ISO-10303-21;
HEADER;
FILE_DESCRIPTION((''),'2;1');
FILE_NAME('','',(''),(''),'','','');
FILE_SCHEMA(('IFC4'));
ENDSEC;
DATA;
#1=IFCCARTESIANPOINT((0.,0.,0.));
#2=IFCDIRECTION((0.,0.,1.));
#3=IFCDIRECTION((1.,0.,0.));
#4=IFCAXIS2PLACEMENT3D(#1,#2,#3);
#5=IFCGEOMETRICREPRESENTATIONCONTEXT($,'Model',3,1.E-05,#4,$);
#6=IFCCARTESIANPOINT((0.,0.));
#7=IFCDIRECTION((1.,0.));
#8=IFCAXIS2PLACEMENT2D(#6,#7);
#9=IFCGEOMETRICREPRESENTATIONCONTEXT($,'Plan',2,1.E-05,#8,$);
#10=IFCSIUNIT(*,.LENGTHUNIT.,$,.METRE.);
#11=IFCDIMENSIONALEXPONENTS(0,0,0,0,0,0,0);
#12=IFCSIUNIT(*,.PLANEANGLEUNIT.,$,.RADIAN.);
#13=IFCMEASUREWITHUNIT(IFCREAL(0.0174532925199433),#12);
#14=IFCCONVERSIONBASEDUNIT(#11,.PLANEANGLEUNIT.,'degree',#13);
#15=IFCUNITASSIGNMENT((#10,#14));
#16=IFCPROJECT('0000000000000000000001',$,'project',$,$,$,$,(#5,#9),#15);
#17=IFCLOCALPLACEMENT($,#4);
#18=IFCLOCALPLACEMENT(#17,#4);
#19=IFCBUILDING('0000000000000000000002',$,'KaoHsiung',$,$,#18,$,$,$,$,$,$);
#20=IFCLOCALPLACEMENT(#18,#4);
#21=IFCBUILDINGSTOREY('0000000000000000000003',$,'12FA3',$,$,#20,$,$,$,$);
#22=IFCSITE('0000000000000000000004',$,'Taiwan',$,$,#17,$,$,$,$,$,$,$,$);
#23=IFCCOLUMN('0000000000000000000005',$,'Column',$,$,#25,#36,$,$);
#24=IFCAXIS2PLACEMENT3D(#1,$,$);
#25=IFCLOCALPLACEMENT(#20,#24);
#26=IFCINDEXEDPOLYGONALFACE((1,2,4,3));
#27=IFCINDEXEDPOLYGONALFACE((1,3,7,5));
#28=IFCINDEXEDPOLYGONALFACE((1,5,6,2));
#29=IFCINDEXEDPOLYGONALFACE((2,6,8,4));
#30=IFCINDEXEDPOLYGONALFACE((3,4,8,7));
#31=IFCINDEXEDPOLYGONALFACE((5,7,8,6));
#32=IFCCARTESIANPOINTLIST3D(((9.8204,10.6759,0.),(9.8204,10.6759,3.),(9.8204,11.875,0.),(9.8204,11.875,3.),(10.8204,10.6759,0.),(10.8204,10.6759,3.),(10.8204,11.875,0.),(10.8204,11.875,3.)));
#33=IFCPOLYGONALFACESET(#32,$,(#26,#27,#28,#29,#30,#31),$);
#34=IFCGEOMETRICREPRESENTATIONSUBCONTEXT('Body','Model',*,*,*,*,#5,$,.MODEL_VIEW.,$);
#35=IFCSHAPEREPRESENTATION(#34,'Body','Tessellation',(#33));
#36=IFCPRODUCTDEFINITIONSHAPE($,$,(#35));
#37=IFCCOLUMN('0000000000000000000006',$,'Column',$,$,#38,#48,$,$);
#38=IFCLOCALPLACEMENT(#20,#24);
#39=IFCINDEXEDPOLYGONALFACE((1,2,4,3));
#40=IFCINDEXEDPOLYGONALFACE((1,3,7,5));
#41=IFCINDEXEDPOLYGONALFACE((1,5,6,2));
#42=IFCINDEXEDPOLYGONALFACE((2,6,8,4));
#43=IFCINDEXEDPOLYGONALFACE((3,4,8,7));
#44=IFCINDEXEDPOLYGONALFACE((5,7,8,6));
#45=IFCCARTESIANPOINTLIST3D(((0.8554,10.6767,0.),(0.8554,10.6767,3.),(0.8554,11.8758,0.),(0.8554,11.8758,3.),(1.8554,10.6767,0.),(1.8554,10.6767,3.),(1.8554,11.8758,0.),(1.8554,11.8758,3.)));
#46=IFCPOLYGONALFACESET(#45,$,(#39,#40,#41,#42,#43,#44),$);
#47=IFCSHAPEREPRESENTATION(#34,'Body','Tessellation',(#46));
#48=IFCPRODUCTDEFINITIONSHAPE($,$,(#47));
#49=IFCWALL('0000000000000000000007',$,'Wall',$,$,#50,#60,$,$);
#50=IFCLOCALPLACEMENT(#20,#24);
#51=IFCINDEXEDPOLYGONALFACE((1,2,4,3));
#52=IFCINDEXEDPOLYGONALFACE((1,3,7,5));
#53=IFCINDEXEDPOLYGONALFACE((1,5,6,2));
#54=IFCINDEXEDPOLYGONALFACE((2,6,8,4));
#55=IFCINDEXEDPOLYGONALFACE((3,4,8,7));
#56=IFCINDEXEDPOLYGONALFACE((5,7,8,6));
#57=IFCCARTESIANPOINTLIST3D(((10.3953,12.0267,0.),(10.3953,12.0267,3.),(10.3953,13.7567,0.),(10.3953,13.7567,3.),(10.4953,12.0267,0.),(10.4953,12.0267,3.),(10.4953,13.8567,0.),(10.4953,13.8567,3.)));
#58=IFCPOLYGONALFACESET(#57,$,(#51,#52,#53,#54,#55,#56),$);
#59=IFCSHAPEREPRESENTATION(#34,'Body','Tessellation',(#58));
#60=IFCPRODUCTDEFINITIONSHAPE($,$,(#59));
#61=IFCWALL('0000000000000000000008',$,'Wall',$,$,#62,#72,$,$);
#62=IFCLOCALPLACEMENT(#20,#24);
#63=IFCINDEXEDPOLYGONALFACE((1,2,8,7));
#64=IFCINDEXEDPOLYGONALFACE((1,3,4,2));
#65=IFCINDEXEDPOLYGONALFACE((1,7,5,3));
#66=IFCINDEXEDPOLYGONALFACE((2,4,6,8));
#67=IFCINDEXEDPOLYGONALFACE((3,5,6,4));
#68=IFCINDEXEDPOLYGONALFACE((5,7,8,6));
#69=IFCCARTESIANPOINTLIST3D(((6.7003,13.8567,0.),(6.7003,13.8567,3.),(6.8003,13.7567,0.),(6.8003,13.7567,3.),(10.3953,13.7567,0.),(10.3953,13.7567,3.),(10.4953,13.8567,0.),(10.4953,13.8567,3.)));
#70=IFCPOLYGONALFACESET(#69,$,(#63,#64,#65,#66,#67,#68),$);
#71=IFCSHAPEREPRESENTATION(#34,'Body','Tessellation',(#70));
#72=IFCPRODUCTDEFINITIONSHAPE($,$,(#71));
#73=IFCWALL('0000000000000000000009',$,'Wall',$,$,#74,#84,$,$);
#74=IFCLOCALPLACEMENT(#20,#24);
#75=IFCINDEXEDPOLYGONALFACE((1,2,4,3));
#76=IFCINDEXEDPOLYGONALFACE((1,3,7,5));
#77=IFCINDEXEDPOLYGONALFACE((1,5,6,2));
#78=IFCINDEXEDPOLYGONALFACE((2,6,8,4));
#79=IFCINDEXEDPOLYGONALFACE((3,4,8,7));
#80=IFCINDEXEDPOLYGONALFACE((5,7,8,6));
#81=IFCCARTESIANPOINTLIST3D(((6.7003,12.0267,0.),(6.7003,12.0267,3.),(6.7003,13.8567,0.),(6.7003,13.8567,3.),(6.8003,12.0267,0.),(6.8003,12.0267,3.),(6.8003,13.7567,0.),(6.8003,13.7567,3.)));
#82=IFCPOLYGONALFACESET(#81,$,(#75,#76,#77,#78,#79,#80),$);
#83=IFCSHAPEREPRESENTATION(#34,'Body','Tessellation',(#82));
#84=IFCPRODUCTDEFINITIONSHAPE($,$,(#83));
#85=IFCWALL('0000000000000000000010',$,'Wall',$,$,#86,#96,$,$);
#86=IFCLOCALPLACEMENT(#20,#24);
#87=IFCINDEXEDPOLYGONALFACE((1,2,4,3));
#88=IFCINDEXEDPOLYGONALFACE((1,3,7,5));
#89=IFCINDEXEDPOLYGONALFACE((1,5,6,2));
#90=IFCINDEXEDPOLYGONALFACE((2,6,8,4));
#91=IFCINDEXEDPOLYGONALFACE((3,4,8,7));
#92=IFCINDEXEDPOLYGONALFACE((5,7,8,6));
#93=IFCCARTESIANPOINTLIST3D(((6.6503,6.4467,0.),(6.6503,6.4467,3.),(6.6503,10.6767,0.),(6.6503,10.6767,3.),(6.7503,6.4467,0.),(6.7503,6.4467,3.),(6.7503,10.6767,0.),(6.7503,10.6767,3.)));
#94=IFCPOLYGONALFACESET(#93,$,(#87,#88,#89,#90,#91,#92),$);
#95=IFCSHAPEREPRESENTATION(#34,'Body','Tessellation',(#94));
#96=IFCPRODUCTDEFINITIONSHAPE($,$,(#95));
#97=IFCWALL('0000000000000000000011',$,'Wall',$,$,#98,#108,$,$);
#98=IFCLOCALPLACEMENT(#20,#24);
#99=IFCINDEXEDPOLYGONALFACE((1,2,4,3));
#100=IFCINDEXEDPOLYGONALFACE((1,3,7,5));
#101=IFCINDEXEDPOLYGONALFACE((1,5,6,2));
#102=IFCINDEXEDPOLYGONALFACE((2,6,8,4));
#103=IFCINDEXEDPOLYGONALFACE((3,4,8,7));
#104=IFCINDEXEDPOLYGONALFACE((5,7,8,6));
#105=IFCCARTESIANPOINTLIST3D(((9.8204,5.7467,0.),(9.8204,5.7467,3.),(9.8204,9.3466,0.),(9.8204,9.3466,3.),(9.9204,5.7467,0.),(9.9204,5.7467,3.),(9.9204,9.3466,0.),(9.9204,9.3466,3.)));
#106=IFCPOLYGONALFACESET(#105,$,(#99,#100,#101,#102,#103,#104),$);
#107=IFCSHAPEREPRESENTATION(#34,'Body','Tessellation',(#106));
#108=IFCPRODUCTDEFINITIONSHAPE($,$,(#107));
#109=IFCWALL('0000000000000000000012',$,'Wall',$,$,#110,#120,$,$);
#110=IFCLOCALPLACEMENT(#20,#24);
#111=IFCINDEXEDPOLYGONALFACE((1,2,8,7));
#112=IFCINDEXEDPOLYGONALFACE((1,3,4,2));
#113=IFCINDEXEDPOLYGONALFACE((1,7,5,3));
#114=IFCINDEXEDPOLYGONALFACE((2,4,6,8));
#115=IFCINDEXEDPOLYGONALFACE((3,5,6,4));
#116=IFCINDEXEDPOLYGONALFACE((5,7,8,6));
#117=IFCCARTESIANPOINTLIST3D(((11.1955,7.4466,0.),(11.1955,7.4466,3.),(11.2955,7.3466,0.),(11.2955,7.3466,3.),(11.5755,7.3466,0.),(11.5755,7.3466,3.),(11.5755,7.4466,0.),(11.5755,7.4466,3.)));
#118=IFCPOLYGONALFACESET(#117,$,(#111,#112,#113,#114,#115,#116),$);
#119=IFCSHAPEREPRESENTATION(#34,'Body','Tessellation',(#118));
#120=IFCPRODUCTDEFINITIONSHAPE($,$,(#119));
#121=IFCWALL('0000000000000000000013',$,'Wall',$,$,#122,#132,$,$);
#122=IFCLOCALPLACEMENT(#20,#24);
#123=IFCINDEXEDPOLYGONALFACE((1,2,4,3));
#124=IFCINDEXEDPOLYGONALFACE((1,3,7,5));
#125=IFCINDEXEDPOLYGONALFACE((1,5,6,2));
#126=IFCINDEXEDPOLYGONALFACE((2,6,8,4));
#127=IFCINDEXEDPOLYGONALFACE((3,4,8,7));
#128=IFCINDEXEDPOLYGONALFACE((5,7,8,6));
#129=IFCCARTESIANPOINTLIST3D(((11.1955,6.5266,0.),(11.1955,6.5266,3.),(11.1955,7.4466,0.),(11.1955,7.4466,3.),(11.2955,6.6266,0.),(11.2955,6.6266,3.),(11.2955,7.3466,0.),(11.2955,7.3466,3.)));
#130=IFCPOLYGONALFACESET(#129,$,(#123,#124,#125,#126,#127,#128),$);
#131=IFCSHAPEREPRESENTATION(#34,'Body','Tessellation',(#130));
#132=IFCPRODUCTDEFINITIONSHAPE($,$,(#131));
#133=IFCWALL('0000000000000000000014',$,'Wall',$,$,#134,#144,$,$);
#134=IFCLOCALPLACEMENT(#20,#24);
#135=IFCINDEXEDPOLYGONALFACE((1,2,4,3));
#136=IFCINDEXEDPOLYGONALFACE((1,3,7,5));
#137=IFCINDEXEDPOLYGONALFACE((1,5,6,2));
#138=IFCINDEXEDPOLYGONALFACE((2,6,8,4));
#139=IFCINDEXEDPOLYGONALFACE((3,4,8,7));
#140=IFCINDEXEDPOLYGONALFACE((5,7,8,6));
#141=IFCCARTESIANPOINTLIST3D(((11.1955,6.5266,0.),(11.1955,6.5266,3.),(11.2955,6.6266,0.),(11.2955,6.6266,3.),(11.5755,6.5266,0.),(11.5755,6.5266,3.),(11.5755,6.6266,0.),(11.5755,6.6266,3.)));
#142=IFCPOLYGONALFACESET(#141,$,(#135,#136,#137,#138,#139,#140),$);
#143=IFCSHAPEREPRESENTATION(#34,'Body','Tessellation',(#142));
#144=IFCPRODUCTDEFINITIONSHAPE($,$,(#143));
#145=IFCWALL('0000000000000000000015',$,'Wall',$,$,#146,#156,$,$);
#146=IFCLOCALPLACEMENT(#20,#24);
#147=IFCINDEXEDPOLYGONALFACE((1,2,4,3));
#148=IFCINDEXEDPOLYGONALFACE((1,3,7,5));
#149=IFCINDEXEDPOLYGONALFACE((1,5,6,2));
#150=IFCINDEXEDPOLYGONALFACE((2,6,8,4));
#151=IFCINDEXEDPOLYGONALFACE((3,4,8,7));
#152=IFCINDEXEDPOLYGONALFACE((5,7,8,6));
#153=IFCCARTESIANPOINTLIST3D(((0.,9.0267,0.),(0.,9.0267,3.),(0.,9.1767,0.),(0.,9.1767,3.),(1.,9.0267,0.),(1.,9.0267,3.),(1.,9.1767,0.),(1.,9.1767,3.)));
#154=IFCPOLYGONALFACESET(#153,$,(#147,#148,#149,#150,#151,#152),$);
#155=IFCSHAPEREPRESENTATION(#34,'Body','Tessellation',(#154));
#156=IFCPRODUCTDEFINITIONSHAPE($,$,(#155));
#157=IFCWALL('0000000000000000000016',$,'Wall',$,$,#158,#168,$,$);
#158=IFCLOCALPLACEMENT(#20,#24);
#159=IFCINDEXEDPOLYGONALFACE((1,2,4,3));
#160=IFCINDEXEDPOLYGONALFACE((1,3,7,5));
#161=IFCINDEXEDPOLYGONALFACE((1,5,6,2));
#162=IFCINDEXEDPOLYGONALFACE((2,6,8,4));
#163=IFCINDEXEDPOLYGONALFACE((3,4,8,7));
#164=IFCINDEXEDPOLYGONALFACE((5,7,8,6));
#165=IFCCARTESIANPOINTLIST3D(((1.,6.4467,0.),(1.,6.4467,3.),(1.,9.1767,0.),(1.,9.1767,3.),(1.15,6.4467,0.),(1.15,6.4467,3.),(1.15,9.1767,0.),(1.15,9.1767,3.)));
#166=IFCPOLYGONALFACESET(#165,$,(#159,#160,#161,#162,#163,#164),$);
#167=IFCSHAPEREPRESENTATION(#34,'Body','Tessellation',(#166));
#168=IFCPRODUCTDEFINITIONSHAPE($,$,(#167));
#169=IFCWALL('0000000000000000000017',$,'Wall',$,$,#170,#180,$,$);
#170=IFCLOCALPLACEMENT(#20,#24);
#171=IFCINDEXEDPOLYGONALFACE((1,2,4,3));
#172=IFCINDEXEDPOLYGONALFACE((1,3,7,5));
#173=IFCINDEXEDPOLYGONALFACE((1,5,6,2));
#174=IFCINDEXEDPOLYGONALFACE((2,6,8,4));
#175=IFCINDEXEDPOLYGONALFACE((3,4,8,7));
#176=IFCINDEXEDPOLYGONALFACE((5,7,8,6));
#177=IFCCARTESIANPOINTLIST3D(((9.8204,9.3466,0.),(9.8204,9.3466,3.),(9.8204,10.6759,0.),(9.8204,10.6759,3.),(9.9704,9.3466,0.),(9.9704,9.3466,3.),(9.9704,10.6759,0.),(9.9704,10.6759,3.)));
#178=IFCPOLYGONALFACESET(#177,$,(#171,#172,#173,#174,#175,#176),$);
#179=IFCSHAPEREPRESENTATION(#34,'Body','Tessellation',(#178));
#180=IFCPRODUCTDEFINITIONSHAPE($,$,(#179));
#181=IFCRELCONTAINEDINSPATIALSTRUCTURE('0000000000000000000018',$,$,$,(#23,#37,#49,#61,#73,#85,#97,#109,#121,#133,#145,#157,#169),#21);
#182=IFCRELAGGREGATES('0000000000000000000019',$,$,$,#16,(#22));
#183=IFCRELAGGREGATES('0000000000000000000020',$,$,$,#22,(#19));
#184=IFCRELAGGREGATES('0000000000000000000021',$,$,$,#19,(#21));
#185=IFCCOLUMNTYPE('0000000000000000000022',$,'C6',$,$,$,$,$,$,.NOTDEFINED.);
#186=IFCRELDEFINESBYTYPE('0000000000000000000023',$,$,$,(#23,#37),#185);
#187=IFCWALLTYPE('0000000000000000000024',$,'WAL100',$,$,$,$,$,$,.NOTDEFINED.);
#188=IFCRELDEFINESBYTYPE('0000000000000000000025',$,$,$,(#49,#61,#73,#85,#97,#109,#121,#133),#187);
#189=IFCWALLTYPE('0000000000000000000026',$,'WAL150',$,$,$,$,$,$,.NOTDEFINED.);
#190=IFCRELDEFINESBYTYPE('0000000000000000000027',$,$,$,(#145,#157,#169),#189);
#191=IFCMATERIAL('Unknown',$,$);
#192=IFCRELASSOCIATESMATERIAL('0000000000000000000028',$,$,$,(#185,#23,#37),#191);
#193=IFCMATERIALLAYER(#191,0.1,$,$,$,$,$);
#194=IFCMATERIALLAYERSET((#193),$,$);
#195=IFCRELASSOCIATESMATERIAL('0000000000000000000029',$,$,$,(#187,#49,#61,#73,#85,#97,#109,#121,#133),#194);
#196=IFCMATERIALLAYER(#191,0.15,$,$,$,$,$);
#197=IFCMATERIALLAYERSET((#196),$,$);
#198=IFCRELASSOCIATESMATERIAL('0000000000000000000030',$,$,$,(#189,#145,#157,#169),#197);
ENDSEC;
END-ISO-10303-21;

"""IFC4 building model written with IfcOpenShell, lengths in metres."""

from ifc_helpers import new_model, entity, si_unit, converted_unit, frame, origin_with_axes, origin_2d_with_axis, place, context, subcontext, project, spatial, line, indexed_curve, outline, extrude, material, layer, layer_set, layer_usage, material_profile, profile_set, profile_usage, type_object, element, save


model = new_model("IFC4")

# Units and contexts
model_context = context("Model", 3, precision=1e-05, world=origin_with_axes())
plan_context = context("Plan", 2, precision=1e-05, world=origin_2d_with_axis())
body_context = subcontext(model_context, "Body", "Model", "MODEL_VIEW")
ifc_project = project(units=[si_unit("LENGTHUNIT", "METRE"), converted_unit("PLANEANGLEUNIT", "degree", entity("IfcReal", 0.0174532925199433), si_unit("PLANEANGLEUNIT", "RADIAN"), dimensions=[0, 0, 0, 0, 0, 0, 0])], contexts=[model_context, plan_context])

# Site, building, storey
site_placement = place(None, origin_with_axes())
site = spatial("IfcSite", under=ifc_project, at=site_placement, Name="Taiwan")
building_placement = place(site_placement, origin_with_axes())
building = spatial("IfcBuilding", under=site, at=building_placement, Name="KaoHsiung")
storey_placement = place(building_placement, origin_with_axes())
storey = spatial("IfcBuildingStorey", under=building, at=storey_placement, Name="12FA3")

# Columns
ifc_material = material(Name="Unknown")
ifc_material_profile = material_profile(ifc_material, outline(indexed_curve([(0.0, 1.1992), (1.0, 1.1992), (1.0, 0.0), (0.0, 0.0), (0.0, 1.1992)])))
ifc_profile_set = profile_set([ifc_material_profile])
ifc_profile_usage_1 = profile_usage(ifc_profile_set, cardinal=5)
column_type = type_object("IfcColumnType", Name="C6", PredefinedType="NOTDEFINED", material=ifc_profile_set)
column_1_placement = place(storey_placement, frame((9.8204, 10.6759, 0.0), z_axis=(0.0, 0.0, 1.0), x_axis=(1.0, 0.0, 0.0)))
element("IfcColumn", 1, at=column_1_placement, inside=storey, type_object=column_type, material=ifc_profile_usage_1, Name="Column", context=body_context, shape_type="SweptSolid", body=[
    extrude(outline(indexed_curve([(0.0, 1.1992), (1.0, 1.1992), (1.0, 0.0), (0.0, 0.0), (0.0, 1.1992)])), origin_with_axes(), (0.0, 0.0, 1.0), 3.0),
])
ifc_profile_usage_2 = profile_usage(ifc_profile_set, cardinal=5)
column_2_placement = place(storey_placement, frame((0.8554, 10.6767, 0.0), z_axis=(0.0, 0.0, 1.0), x_axis=(1.0, 0.0, 0.0)))
element("IfcColumn", 2, at=column_2_placement, inside=storey, type_object=column_type, material=ifc_profile_usage_2, Name="Column", context=body_context, shape_type="SweptSolid", body=[
    extrude(outline(indexed_curve([(0.0, 1.1992), (1.0, 1.1992), (1.0, 0.0), (0.0, 0.0), (0.0, 1.1992)])), origin_with_axes(), (0.0, 0.0, 1.0), 3.0),
])

# Walls
ifc_layer_1 = layer(ifc_material, 0.1)
ifc_layer_set_1 = layer_set([ifc_layer_1])
ifc_layer_usage_1 = layer_usage(ifc_layer_set_1, "AXIS2", "POSITIVE", 0.0)
wall_type_1 = type_object("IfcWallType", Name="WAL100", PredefinedType="NOTDEFINED", material=ifc_layer_set_1)
wall_1_placement = place(storey_placement, frame((10.4953, 12.0267, 0.0), z_axis=(0.0, 0.0, 1.0), x_axis=(0.0, 1.0, 0.0)))
element("IfcWall", 3, at=wall_1_placement, inside=storey, type_object=wall_type_1, material=ifc_layer_usage_1, Name="Wall", context=body_context, shape_type="SweptSolid", body=[
    extrude(outline(indexed_curve([(0.0, 0.0), (0.0, 0.1), (1.73, 0.1), (1.83, 0.0)], segments=[line(1, 2, 3, 4, 1)])), origin_with_axes(), (0.0, 0.0, 1.0), 3.0),
])
ifc_layer_usage_2 = layer_usage(ifc_layer_set_1, "AXIS2", "POSITIVE", 0.0)
wall_2_placement = place(storey_placement, frame((10.4953, 13.8567, 0.0), z_axis=(0.0, 0.0, 1.0), x_axis=(-1.0, 0.0, 0.0)))
element("IfcWall", 4, at=wall_2_placement, inside=storey, type_object=wall_type_1, material=ifc_layer_usage_2, Name="Wall", context=body_context, shape_type="SweptSolid", body=[
    extrude(outline(indexed_curve([(0.0, 0.0), (0.1, 0.1), (3.695, 0.1), (3.795, 0.0)], segments=[line(1, 2, 3, 4, 1)])), origin_with_axes(), (0.0, 0.0, 1.0), 3.0),
])
ifc_layer_usage_3 = layer_usage(ifc_layer_set_1, "AXIS2", "POSITIVE", 0.0)
wall_3_placement = place(storey_placement, frame((6.7003, 13.8567, 0.0), z_axis=(0.0, 0.0, 1.0), x_axis=(0.0, -1.0, 0.0)))
element("IfcWall", 5, at=wall_3_placement, inside=storey, type_object=wall_type_1, material=ifc_layer_usage_3, Name="Wall", context=body_context, shape_type="SweptSolid", body=[
    extrude(outline(indexed_curve([(0.0, 0.0), (0.1, 0.1), (1.8299, 0.1), (1.8299, 0.0)], segments=[line(1, 2, 3, 4, 1)])), origin_with_axes(), (0.0, 0.0, 1.0), 3.0),
])
ifc_layer_usage_4 = layer_usage(ifc_layer_set_1, "AXIS2", "POSITIVE", 0.0)
wall_4_placement = place(storey_placement, frame((6.6503, 10.6767, 0.0), z_axis=(0.0, 0.0, 1.0), x_axis=(0.0, -1.0, 0.0)))
element("IfcWall", 6, at=wall_4_placement, inside=storey, type_object=wall_type_1, material=ifc_layer_usage_4, Name="Wall", context=body_context, shape_type="SweptSolid", body=[
    extrude(outline(indexed_curve([(0.0, 0.0), (0.0, 0.1), (4.23, 0.1), (4.23, 0.0)], segments=[line(1, 2, 3, 4, 1)])), origin_with_axes(), (0.0, 0.0, 1.0), 3.0),
])
ifc_layer_usage_5 = layer_usage(ifc_layer_set_1, "AXIS2", "POSITIVE", 0.0)
wall_5_placement = place(storey_placement, frame((9.8204, 9.3466, 0.0), z_axis=(0.0, 0.0, 1.0), x_axis=(0.0, -1.0, 0.0)))
element("IfcWall", 7, at=wall_5_placement, inside=storey, type_object=wall_type_1, material=ifc_layer_usage_5, Name="Wall", context=body_context, shape_type="SweptSolid", body=[
    extrude(outline(indexed_curve([(0.0, 0.0), (0.0, 0.1), (3.5999, 0.1), (3.5999, 0.0)], segments=[line(1, 2, 3, 4, 1)])), origin_with_axes(), (0.0, 0.0, 1.0), 3.0),
])
ifc_layer_usage_6 = layer_usage(ifc_layer_set_1, "AXIS2", "POSITIVE", 0.0)
wall_6_placement = place(storey_placement, frame((11.5755, 7.4466, 0.0), z_axis=(0.0, 0.0, 1.0), x_axis=(-1.0, 0.0, 0.0)))
element("IfcWall", 8, at=wall_6_placement, inside=storey, type_object=wall_type_1, material=ifc_layer_usage_6, Name="Wall", context=body_context, shape_type="SweptSolid", body=[
    extrude(outline(indexed_curve([(0.0, 0.0), (0.0, 0.1), (0.28, 0.1), (0.38, 0.0)], segments=[line(1, 2, 3, 4, 1)])), origin_with_axes(), (0.0, 0.0, 1.0), 3.0),
])
ifc_layer_usage_7 = layer_usage(ifc_layer_set_1, "AXIS2", "POSITIVE", 0.0)
wall_7_placement = place(storey_placement, frame((11.1955, 7.4466, 0.0), z_axis=(0.0, 0.0, 1.0), x_axis=(0.0, -1.0, 0.0)))
element("IfcWall", 9, at=wall_7_placement, inside=storey, type_object=wall_type_1, material=ifc_layer_usage_7, Name="Wall", context=body_context, shape_type="SweptSolid", body=[
    extrude(outline(indexed_curve([(0.0, 0.0), (0.1, 0.1), (0.82, 0.1), (0.92, 0.0)], segments=[line(1, 2, 3, 4, 1)])), origin_with_axes(), (0.0, 0.0, 1.0), 3.0),
])
ifc_layer_usage_8 = layer_usage(ifc_layer_set_1, "AXIS2", "POSITIVE", 0.0)
wall_8_placement = place(storey_placement, frame((11.1955, 6.5266, 0.0), z_axis=(0.0, 0.0, 1.0), x_axis=(1.0, 0.0, 0.0)))
element("IfcWall", 10, at=wall_8_placement, inside=storey, type_object=wall_type_1, material=ifc_layer_usage_8, Name="Wall", context=body_context, shape_type="SweptSolid", body=[
    extrude(outline(indexed_curve([(0.0, 0.0), (0.1, 0.1), (0.38, 0.1), (0.38, 0.0)], segments=[line(1, 2, 3, 4, 1)])), origin_with_axes(), (0.0, 0.0, 1.0), 3.0),
])
ifc_layer_2 = layer(ifc_material, 0.15)
ifc_layer_set_2 = layer_set([ifc_layer_2])
ifc_layer_usage_9 = layer_usage(ifc_layer_set_2, "AXIS2", "POSITIVE", 0.0)
wall_type_2 = type_object("IfcWallType", Name="WAL150", PredefinedType="NOTDEFINED", material=ifc_layer_set_2)
wall_9_placement = place(storey_placement, frame((0.0, 9.0267, 0.0), z_axis=(0.0, 0.0, 1.0), x_axis=(1.0, 0.0, 0.0)))
element("IfcWall", 11, at=wall_9_placement, inside=storey, type_object=wall_type_2, material=ifc_layer_usage_9, Name="Wall", context=body_context, shape_type="SweptSolid", body=[
    extrude(outline(indexed_curve([(0.0, 0.0), (0.0, 0.15), (1.0, 0.15), (1.0, 0.0)], segments=[line(1, 2, 3, 4, 1)])), origin_with_axes(), (0.0, 0.0, 1.0), 3.0),
])
ifc_layer_usage_10 = layer_usage(ifc_layer_set_2, "AXIS2", "POSITIVE", 0.0)
wall_10_placement = place(storey_placement, frame((1.0, 9.1767, 0.0), z_axis=(0.0, 0.0, 1.0), x_axis=(0.0, -1.0, 0.0)))
element("IfcWall", 12, at=wall_10_placement, inside=storey, type_object=wall_type_2, material=ifc_layer_usage_10, Name="Wall", context=body_context, shape_type="SweptSolid", body=[
    extrude(outline(indexed_curve([(0.0, 0.0), (0.0, 0.15), (2.73, 0.15), (2.73, 0.0)], segments=[line(1, 2, 3, 4, 1)])), origin_with_axes(), (0.0, 0.0, 1.0), 3.0),
])
ifc_layer_usage_11 = layer_usage(ifc_layer_set_2, "AXIS2", "POSITIVE", 0.0)
wall_11_placement = place(storey_placement, frame((9.9704, 9.3466, 0.0), z_axis=(0.0, 0.0, 1.0), x_axis=(0.0, 1.0, 0.0)))
element("IfcWall", 13, at=wall_11_placement, inside=storey, type_object=wall_type_2, material=ifc_layer_usage_11, Name="Wall", context=body_context, shape_type="SweptSolid", body=[
    extrude(outline(indexed_curve([(0.0, 0.0), (0.0, 0.15), (1.3293, 0.15), (1.3293, 0.0)], segments=[line(1, 2, 3, 4, 1)])), origin_with_axes(), (0.0, 0.0, 1.0), 3.0),
])

save(model, "model.ifc")
